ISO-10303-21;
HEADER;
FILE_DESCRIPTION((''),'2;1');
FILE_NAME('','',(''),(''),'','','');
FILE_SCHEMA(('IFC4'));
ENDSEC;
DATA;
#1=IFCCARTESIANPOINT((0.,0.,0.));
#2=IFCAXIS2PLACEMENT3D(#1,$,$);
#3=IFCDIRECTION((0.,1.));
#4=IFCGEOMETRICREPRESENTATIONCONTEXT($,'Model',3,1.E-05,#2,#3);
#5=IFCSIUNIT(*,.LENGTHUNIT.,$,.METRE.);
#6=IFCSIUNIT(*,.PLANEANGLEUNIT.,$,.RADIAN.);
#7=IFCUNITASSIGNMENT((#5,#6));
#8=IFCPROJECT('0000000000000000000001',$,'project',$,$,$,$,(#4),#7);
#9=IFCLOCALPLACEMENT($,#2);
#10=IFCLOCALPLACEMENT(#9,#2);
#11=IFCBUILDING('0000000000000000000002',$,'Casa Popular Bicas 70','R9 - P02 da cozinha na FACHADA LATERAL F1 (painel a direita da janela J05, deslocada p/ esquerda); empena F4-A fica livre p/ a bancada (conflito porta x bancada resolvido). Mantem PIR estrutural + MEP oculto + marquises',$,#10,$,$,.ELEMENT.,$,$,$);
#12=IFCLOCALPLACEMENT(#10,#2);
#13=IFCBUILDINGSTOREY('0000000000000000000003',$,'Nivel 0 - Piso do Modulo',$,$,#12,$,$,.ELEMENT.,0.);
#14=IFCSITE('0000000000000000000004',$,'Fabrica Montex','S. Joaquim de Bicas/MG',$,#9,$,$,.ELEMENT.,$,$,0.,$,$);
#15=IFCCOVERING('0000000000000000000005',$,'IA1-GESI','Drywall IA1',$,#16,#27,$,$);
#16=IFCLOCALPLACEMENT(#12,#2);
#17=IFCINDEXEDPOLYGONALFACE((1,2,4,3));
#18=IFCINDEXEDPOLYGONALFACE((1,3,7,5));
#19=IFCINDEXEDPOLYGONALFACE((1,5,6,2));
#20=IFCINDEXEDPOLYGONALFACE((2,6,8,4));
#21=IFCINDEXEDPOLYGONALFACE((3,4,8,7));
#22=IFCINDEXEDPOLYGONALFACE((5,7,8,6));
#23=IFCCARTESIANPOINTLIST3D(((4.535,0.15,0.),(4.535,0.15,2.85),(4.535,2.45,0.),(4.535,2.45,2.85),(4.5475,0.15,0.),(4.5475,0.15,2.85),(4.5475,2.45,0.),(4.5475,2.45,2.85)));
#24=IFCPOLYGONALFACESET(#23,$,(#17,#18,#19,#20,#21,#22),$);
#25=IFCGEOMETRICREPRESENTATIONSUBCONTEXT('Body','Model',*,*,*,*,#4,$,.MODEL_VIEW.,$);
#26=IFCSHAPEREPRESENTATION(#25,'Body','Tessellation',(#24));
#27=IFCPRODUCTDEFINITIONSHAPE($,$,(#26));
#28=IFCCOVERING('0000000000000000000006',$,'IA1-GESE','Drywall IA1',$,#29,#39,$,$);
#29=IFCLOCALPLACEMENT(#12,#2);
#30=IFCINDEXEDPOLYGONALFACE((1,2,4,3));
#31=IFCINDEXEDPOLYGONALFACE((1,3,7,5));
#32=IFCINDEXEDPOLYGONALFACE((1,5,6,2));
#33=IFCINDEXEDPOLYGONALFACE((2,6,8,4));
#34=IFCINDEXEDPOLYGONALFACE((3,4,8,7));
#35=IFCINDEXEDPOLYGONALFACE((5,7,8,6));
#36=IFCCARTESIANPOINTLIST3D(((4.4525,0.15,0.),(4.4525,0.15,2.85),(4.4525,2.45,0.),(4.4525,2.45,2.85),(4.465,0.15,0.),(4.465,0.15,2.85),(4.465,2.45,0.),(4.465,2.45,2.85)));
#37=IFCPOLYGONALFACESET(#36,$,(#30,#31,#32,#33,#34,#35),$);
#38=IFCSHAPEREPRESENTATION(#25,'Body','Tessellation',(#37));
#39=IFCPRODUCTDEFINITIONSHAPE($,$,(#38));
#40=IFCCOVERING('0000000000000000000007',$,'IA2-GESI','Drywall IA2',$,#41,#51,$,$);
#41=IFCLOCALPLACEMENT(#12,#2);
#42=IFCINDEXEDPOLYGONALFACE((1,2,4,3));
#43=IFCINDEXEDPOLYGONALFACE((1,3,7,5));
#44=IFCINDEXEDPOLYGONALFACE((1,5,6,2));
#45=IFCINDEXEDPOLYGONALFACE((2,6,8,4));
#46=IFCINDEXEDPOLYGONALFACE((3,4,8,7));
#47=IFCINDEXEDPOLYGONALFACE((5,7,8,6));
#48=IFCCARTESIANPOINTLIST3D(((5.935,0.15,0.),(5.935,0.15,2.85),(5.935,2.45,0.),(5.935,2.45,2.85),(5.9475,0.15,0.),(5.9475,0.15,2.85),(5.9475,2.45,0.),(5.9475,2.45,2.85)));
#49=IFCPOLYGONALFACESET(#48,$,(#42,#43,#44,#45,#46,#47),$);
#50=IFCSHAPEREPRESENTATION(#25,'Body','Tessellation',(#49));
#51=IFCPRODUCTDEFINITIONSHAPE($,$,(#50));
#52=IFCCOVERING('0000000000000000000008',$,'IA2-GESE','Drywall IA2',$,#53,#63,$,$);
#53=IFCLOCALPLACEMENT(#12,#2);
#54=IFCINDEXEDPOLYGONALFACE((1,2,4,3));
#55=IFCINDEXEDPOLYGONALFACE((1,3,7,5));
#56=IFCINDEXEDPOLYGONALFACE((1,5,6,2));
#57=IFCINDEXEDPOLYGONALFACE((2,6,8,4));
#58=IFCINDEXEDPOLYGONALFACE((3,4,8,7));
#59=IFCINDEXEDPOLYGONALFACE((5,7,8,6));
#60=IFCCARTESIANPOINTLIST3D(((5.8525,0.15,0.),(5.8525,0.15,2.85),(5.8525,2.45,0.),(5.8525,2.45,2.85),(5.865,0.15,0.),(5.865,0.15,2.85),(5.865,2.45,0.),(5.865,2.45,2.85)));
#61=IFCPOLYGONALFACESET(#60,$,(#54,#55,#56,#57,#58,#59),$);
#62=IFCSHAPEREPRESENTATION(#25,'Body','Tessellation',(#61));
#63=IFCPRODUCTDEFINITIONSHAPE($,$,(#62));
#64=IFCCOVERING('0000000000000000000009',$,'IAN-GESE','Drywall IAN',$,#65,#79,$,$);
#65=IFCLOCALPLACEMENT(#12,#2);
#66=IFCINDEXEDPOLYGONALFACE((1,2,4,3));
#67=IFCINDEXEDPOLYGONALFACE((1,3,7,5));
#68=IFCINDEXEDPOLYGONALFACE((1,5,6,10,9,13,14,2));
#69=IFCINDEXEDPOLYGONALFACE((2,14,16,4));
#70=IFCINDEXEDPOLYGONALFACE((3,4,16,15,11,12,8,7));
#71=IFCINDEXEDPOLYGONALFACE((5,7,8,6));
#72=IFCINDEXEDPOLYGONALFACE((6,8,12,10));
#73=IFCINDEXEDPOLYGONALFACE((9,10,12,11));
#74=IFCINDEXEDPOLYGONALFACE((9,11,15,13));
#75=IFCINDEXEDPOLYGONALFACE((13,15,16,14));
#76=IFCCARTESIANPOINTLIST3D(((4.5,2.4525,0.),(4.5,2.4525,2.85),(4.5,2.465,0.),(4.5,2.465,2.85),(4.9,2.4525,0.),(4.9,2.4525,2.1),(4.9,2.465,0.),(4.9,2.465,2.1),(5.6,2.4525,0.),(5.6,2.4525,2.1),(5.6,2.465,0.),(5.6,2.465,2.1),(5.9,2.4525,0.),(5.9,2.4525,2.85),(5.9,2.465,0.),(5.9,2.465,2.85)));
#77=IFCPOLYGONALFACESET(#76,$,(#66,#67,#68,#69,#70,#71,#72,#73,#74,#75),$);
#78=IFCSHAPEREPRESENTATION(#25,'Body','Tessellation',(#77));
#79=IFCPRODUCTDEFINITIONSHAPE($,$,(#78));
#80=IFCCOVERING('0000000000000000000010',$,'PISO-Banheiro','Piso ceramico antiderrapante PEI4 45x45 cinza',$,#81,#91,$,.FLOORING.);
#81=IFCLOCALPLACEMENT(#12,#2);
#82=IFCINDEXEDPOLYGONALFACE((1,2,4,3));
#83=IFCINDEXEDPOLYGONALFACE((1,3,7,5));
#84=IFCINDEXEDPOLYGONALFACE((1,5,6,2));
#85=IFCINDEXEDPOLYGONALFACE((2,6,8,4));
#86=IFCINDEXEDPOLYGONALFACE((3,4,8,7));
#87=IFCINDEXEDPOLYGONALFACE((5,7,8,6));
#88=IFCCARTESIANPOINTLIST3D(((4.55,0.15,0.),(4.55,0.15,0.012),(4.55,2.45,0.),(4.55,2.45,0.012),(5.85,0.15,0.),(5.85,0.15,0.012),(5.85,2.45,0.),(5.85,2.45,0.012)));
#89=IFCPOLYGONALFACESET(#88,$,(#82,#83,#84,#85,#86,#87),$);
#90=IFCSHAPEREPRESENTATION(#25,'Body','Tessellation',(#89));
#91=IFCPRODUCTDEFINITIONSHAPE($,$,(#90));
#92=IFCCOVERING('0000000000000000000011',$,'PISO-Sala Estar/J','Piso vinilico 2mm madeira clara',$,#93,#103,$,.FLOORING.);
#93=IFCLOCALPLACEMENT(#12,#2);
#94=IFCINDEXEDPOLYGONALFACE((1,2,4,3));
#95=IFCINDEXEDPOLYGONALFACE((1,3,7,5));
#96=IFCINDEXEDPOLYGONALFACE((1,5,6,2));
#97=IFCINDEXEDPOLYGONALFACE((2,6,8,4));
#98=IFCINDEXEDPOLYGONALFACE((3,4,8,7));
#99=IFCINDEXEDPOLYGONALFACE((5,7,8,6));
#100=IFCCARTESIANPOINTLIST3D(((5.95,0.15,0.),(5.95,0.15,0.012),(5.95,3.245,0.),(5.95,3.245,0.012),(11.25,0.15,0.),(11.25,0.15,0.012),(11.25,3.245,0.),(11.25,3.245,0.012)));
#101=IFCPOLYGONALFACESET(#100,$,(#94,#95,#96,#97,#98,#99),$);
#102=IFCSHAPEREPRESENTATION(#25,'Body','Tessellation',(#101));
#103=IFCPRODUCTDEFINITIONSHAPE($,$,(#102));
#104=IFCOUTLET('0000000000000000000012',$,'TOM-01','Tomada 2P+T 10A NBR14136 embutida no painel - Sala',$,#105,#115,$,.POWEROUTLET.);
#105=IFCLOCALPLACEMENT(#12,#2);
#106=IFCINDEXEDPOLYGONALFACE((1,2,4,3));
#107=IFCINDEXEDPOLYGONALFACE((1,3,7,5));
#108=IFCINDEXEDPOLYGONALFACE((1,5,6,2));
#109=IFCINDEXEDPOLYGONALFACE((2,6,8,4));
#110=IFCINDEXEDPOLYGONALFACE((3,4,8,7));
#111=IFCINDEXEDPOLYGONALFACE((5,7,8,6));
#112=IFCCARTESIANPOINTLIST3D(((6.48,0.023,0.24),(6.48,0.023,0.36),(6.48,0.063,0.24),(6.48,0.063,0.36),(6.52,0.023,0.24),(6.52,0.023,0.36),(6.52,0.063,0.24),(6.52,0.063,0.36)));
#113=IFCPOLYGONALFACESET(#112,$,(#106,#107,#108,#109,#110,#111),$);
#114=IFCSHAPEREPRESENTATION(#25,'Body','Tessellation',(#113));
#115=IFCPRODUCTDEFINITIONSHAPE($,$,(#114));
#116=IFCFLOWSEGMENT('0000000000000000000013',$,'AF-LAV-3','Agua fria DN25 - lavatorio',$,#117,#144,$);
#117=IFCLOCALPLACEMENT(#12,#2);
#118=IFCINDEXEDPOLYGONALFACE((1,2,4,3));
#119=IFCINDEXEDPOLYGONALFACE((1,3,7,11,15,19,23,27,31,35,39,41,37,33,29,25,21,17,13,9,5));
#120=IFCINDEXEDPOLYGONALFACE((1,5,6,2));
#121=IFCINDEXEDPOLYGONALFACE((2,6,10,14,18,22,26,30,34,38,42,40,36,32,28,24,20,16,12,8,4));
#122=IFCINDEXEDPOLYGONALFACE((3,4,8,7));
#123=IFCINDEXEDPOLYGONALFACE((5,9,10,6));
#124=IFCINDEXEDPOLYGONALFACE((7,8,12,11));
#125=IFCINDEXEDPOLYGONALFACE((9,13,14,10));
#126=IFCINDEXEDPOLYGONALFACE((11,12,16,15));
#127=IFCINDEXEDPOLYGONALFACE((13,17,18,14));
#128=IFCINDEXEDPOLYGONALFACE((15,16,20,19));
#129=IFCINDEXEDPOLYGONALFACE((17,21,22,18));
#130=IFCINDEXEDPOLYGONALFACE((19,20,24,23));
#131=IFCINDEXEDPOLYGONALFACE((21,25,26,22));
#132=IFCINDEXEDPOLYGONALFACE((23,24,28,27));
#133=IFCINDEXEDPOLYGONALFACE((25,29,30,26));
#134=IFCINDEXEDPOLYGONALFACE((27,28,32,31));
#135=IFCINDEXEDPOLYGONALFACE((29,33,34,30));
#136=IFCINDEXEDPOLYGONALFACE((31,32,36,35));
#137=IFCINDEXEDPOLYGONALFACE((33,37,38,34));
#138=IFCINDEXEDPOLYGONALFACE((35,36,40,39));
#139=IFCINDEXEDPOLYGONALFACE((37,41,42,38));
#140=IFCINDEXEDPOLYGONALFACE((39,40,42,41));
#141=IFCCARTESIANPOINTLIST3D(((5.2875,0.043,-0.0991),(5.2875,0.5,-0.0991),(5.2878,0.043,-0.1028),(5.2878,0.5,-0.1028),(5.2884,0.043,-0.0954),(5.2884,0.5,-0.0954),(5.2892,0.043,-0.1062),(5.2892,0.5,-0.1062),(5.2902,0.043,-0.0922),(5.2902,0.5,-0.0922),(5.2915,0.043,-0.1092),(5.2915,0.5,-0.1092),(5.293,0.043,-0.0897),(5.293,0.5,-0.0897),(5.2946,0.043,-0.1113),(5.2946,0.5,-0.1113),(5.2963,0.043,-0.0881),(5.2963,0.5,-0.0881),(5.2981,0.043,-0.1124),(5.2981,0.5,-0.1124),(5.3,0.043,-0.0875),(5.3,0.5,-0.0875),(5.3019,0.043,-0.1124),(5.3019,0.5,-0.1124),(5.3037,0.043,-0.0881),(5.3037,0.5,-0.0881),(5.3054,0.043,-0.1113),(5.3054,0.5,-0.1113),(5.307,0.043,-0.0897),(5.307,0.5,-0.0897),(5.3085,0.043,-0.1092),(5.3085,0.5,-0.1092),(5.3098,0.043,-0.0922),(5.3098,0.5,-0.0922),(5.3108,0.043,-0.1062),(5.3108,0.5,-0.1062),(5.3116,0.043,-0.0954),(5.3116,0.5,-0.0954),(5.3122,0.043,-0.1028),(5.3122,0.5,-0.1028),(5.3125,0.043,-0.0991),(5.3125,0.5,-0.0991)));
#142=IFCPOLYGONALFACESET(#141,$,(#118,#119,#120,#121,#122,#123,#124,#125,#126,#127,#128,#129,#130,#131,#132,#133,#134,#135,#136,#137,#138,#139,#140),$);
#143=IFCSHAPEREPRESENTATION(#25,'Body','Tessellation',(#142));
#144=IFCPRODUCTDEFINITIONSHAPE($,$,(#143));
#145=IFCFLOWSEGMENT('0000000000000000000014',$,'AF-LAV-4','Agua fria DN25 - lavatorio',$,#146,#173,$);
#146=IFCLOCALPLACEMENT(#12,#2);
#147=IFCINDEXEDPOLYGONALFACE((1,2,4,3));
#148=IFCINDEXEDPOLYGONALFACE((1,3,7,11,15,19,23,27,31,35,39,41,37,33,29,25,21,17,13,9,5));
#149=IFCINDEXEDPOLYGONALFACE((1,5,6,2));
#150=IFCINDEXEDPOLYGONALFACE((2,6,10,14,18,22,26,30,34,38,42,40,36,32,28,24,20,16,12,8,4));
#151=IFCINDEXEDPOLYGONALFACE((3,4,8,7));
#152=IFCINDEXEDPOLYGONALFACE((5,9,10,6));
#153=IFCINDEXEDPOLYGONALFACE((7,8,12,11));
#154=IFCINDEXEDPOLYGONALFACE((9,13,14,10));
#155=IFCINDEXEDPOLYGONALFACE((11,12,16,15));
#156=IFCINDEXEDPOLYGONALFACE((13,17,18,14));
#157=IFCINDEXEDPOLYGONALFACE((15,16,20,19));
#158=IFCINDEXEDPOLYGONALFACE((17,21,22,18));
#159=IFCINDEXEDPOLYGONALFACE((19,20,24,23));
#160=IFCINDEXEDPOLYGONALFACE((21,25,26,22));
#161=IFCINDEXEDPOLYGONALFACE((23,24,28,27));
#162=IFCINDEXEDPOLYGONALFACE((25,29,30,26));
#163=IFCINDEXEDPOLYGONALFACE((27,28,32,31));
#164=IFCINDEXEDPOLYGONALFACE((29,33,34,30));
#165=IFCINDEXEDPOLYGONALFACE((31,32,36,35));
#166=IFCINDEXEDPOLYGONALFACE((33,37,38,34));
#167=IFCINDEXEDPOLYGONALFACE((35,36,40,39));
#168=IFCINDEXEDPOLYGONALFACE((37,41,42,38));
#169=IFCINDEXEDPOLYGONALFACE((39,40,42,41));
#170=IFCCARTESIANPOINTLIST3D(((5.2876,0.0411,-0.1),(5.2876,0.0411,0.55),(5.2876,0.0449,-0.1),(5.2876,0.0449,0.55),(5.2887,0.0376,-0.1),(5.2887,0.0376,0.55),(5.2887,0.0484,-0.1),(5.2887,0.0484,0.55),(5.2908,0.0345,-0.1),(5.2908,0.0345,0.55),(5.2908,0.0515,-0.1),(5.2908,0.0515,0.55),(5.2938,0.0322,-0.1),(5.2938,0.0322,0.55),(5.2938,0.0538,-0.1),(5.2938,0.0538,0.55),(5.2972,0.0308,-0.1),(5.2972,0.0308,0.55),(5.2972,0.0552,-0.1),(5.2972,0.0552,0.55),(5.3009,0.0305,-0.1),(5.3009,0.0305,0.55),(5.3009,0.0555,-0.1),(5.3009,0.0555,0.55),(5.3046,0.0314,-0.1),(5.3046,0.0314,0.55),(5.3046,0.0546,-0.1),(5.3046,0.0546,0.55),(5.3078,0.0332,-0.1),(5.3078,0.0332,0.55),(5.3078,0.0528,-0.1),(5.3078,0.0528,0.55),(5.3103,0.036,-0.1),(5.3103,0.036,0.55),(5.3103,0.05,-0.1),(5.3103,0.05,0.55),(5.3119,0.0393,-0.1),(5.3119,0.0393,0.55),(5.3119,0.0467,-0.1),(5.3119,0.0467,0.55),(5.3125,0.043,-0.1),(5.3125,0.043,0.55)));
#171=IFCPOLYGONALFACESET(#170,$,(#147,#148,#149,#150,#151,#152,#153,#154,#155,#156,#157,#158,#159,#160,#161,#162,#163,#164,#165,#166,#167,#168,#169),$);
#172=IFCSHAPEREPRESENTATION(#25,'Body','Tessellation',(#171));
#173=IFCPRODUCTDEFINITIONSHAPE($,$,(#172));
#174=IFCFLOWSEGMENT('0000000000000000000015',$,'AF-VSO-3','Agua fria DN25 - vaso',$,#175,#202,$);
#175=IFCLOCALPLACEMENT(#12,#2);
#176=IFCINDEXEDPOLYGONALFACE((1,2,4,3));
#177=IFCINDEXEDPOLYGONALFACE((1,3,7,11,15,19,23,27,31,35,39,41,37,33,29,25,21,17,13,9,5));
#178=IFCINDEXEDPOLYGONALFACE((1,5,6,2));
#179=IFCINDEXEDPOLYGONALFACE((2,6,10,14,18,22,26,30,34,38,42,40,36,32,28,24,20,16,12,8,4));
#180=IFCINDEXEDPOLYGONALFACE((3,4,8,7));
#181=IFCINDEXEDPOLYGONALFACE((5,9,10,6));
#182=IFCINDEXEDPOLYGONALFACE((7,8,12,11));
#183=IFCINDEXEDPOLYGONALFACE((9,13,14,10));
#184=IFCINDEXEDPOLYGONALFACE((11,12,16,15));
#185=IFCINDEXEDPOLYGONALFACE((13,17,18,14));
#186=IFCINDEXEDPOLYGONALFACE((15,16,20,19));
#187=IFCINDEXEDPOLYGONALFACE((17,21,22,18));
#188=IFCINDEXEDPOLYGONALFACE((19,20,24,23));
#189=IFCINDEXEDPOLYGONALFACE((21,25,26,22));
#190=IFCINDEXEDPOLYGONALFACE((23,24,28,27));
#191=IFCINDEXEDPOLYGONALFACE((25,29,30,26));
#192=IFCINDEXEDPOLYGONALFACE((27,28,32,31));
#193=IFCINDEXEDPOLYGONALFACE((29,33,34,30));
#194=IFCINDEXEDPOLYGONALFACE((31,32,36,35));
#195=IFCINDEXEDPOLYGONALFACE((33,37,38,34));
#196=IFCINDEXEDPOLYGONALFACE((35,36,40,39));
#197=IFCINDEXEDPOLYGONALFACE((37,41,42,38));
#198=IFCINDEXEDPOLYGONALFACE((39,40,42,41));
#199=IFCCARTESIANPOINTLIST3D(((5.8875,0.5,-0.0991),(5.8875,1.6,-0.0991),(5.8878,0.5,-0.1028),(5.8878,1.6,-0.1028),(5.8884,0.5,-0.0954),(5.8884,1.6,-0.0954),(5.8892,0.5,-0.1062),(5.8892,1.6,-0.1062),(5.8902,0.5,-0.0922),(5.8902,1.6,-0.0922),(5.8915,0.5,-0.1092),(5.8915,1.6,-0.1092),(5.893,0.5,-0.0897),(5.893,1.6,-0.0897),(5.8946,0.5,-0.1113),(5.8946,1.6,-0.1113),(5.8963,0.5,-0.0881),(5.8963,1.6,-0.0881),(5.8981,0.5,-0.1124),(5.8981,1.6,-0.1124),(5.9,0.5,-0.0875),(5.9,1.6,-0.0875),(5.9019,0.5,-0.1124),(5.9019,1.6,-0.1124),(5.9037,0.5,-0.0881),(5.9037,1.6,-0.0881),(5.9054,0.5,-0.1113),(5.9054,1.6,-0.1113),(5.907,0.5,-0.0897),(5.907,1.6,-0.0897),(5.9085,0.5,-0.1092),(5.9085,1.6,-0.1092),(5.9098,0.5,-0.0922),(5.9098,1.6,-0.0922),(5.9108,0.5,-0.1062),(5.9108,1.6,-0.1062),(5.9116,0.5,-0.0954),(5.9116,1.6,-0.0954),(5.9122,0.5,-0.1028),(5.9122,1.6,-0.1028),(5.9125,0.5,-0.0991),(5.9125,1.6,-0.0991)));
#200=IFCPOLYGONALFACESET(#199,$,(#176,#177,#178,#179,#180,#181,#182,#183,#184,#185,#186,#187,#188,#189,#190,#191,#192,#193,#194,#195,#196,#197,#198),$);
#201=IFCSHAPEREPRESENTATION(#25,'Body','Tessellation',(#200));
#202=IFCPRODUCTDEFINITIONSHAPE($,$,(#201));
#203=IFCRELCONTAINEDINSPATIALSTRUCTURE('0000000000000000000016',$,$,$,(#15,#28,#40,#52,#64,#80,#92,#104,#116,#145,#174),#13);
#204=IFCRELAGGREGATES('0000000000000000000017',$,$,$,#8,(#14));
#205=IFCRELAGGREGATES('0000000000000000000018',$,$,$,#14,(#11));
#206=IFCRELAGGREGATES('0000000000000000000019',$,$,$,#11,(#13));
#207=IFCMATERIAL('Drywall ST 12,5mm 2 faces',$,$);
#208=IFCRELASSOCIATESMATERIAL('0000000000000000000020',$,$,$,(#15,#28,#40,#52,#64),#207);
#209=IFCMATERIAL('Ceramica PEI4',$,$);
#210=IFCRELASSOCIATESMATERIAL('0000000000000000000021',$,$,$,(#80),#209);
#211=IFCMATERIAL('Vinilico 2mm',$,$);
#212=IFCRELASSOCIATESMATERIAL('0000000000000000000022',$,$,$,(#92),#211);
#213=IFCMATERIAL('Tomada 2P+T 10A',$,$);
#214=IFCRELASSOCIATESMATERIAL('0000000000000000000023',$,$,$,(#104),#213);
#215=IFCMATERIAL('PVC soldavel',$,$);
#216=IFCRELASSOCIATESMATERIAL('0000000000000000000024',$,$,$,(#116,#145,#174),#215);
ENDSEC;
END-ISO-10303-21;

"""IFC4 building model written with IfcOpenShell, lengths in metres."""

from ifc_helpers import new_model, si_unit, direction, frame, frame_2d, origin, origin_2d, place, context, subcontext, project, spatial, rectangle, circle, extrude, material, element, save


model = new_model("IFC4")

# Units and contexts
model_context = context("Model", 3, precision=1e-05, world=origin(), true_north=direction((0.0, 1.0)))
body_context = subcontext(model_context, "Body", "Model", "MODEL_VIEW")
ifc_project = project(units=[si_unit("LENGTHUNIT", "METRE"), si_unit("PLANEANGLEUNIT", "RADIAN")], contexts=[model_context])

# Site, building, storey
site_placement = place(None, origin())
site = spatial("IfcSite", under=ifc_project, at=site_placement, Name="Fabrica Montex", Description="S. Joaquim de Bicas/MG", CompositionType="ELEMENT", RefElevation=0.0)
building_placement = place(site_placement, origin())
building = spatial("IfcBuilding", under=site, at=building_placement, Name="Casa Popular Bicas 70", Description="R9 - P02 da cozinha na FACHADA LATERAL F1 (painel a direita da janela J05, deslocada p/ esquerda); empena F4-A fica livre p/ a bancada (conflito porta x bancada resolvido). Mantem PIR estrutural + MEP oculto + marquises", CompositionType="ELEMENT")
storey_placement = place(building_placement, origin())
storey = spatial("IfcBuildingStorey", under=building, at=storey_placement, Name="Nivel 0 - Piso do Modulo", CompositionType="ELEMENT", Elevation=0.0)

# Coverings
ifc_material_1 = material(Name="Drywall ST 12,5mm 2 faces")
for number, where, x_axis, name, description in (
    (1, (4.5412, 0.15, 0.0), (0.0, 1.0, 0.0), "IA1-GESI", "Drywall IA1"),
    (2, (4.4588, 0.15, 0.0), (0.0, 1.0, 0.0), "IA1-GESE", "Drywall IA1"),
    (3, (5.9413, 0.15, 0.0), (0.0, 1.0, 0.0), "IA2-GESI", "Drywall IA2"),
    (4, (5.8588, 0.15, 0.0), (0.0, 1.0, 0.0), "IA2-GESE", "Drywall IA2"),
):
    element("IfcCovering", number, at=place(storey_placement, frame(where, x_axis=x_axis)), inside=storey, material=ifc_material_1, Name=name, Description=description, context=body_context, shape_type="SweptSolid", body=[
        extrude(rectangle(XDim=2.3, YDim=0.0125, at=frame_2d((1.15, 0.0))), origin(), (0.0, 0.0, 1.0), 2.85),
    ])

# Covering, opening
covering_1_placement = place(storey_placement, frame((4.5, 2.4588, 0.0), x_axis=(1.0, 0.0, 0.0)))
covering_1 = element("IfcCovering", 5, at=covering_1_placement, inside=storey, material=ifc_material_1, Name="IAN-GESE", Description="Drywall IAN", context=body_context, shape_type="SweptSolid", body=[
    extrude(rectangle(XDim=1.4, YDim=0.0125, at=frame_2d((0.7, 0.0))), origin(), (0.0, 0.0, 1.0), 2.85),
])
opening_1_placement = place(storey_placement, frame((5.25, 2.4588, 0.0)))
element("IfcOpeningElement", 6, at=opening_1_placement, cuts=covering_1, PredefinedType="OPENING", context=body_context, shape_type="SweptSolid", body=[
    extrude(rectangle(XDim=0.7, YDim=0.0425, at=origin_2d()), origin(), (0.0, 0.0, 1.0), 2.1),
])

# Coverings
ifc_material_2 = material(Name="Ceramica PEI4")
covering_2_placement = place(storey_placement, frame((4.55, 0.15, 0.0)))
element("IfcCovering", 7, at=covering_2_placement, inside=storey, material=ifc_material_2, Name="PISO-Banheiro", Description="Piso ceramico antiderrapante PEI4 45x45 cinza", PredefinedType="FLOORING", context=body_context, shape_type="SweptSolid", body=[
    extrude(rectangle(XDim=1.3, YDim=2.3, at=frame_2d((0.65, 1.15))), origin(), (0.0, 0.0, 1.0), 0.012),
])
ifc_material_3 = material(Name="Vinilico 2mm")
covering_3_placement = place(storey_placement, frame((5.95, 0.15, 0.0)))
element("IfcCovering", 8, at=covering_3_placement, inside=storey, material=ifc_material_3, Name="PISO-Sala Estar/J", Description="Piso vinilico 2mm madeira clara", PredefinedType="FLOORING", context=body_context, shape_type="SweptSolid", body=[
    extrude(rectangle(XDim=5.3, YDim=3.095, at=frame_2d((2.65, 1.5475))), origin(), (0.0, 0.0, 1.0), 0.012),
])

# Outlet
ifc_material_4 = material(Name="Tomada 2P+T 10A")
outlet_placement = place(storey_placement, frame((6.48, 0.023, 0.24)))
element("IfcOutlet", 9, at=outlet_placement, inside=storey, material=ifc_material_4, Name="TOM-01", Description="Tomada 2P+T 10A NBR14136 embutida no painel - Sala", PredefinedType="POWEROUTLET", context=body_context, shape_type="SweptSolid", body=[
    extrude(rectangle(XDim=0.04, YDim=0.04, at=frame_2d((0.02, 0.02))), origin(), (0.0, 0.0, 1.0), 0.12),
])

# Flow segments
ifc_material_5 = material(Name="PVC soldavel")
flow_segment_1_placement = place(storey_placement, frame((5.3, 0.5, -0.1), z_axis=(0.0, -1.0, 0.0), x_axis=(0.0, 0.0, 1.0)))
element("IfcFlowSegment", 10, at=flow_segment_1_placement, inside=storey, material=ifc_material_5, Name="AF-LAV-3", Description="Agua fria DN25 - lavatorio", context=body_context, shape_type="SweptSolid", body=[
    extrude(circle(Radius=0.0125, at=origin_2d()), origin(), (0.0, 0.0, 1.0), 0.457),
])
flow_segment_2_placement = place(storey_placement, frame((5.3, 0.043, -0.1), z_axis=(0.0, 0.0, 1.0), x_axis=(1.0, 0.0, 0.0)))
element("IfcFlowSegment", 11, at=flow_segment_2_placement, inside=storey, material=ifc_material_5, Name="AF-LAV-4", Description="Agua fria DN25 - lavatorio", context=body_context, shape_type="SweptSolid", body=[
    extrude(circle(Radius=0.0125, at=origin_2d()), origin(), (0.0, 0.0, 1.0), 0.65),
])
flow_segment_3_placement = place(storey_placement, frame((5.9, 0.5, -0.1), z_axis=(0.0, 1.0, 0.0), x_axis=(0.0, 0.0, 1.0)))
element("IfcFlowSegment", 12, at=flow_segment_3_placement, inside=storey, material=ifc_material_5, Name="AF-VSO-3", Description="Agua fria DN25 - vaso", context=body_context, shape_type="SweptSolid", body=[
    extrude(circle(Radius=0.0125, at=origin_2d()), origin(), (0.0, 0.0, 1.0), 1.1),
])

save(model, "model.ifc")
